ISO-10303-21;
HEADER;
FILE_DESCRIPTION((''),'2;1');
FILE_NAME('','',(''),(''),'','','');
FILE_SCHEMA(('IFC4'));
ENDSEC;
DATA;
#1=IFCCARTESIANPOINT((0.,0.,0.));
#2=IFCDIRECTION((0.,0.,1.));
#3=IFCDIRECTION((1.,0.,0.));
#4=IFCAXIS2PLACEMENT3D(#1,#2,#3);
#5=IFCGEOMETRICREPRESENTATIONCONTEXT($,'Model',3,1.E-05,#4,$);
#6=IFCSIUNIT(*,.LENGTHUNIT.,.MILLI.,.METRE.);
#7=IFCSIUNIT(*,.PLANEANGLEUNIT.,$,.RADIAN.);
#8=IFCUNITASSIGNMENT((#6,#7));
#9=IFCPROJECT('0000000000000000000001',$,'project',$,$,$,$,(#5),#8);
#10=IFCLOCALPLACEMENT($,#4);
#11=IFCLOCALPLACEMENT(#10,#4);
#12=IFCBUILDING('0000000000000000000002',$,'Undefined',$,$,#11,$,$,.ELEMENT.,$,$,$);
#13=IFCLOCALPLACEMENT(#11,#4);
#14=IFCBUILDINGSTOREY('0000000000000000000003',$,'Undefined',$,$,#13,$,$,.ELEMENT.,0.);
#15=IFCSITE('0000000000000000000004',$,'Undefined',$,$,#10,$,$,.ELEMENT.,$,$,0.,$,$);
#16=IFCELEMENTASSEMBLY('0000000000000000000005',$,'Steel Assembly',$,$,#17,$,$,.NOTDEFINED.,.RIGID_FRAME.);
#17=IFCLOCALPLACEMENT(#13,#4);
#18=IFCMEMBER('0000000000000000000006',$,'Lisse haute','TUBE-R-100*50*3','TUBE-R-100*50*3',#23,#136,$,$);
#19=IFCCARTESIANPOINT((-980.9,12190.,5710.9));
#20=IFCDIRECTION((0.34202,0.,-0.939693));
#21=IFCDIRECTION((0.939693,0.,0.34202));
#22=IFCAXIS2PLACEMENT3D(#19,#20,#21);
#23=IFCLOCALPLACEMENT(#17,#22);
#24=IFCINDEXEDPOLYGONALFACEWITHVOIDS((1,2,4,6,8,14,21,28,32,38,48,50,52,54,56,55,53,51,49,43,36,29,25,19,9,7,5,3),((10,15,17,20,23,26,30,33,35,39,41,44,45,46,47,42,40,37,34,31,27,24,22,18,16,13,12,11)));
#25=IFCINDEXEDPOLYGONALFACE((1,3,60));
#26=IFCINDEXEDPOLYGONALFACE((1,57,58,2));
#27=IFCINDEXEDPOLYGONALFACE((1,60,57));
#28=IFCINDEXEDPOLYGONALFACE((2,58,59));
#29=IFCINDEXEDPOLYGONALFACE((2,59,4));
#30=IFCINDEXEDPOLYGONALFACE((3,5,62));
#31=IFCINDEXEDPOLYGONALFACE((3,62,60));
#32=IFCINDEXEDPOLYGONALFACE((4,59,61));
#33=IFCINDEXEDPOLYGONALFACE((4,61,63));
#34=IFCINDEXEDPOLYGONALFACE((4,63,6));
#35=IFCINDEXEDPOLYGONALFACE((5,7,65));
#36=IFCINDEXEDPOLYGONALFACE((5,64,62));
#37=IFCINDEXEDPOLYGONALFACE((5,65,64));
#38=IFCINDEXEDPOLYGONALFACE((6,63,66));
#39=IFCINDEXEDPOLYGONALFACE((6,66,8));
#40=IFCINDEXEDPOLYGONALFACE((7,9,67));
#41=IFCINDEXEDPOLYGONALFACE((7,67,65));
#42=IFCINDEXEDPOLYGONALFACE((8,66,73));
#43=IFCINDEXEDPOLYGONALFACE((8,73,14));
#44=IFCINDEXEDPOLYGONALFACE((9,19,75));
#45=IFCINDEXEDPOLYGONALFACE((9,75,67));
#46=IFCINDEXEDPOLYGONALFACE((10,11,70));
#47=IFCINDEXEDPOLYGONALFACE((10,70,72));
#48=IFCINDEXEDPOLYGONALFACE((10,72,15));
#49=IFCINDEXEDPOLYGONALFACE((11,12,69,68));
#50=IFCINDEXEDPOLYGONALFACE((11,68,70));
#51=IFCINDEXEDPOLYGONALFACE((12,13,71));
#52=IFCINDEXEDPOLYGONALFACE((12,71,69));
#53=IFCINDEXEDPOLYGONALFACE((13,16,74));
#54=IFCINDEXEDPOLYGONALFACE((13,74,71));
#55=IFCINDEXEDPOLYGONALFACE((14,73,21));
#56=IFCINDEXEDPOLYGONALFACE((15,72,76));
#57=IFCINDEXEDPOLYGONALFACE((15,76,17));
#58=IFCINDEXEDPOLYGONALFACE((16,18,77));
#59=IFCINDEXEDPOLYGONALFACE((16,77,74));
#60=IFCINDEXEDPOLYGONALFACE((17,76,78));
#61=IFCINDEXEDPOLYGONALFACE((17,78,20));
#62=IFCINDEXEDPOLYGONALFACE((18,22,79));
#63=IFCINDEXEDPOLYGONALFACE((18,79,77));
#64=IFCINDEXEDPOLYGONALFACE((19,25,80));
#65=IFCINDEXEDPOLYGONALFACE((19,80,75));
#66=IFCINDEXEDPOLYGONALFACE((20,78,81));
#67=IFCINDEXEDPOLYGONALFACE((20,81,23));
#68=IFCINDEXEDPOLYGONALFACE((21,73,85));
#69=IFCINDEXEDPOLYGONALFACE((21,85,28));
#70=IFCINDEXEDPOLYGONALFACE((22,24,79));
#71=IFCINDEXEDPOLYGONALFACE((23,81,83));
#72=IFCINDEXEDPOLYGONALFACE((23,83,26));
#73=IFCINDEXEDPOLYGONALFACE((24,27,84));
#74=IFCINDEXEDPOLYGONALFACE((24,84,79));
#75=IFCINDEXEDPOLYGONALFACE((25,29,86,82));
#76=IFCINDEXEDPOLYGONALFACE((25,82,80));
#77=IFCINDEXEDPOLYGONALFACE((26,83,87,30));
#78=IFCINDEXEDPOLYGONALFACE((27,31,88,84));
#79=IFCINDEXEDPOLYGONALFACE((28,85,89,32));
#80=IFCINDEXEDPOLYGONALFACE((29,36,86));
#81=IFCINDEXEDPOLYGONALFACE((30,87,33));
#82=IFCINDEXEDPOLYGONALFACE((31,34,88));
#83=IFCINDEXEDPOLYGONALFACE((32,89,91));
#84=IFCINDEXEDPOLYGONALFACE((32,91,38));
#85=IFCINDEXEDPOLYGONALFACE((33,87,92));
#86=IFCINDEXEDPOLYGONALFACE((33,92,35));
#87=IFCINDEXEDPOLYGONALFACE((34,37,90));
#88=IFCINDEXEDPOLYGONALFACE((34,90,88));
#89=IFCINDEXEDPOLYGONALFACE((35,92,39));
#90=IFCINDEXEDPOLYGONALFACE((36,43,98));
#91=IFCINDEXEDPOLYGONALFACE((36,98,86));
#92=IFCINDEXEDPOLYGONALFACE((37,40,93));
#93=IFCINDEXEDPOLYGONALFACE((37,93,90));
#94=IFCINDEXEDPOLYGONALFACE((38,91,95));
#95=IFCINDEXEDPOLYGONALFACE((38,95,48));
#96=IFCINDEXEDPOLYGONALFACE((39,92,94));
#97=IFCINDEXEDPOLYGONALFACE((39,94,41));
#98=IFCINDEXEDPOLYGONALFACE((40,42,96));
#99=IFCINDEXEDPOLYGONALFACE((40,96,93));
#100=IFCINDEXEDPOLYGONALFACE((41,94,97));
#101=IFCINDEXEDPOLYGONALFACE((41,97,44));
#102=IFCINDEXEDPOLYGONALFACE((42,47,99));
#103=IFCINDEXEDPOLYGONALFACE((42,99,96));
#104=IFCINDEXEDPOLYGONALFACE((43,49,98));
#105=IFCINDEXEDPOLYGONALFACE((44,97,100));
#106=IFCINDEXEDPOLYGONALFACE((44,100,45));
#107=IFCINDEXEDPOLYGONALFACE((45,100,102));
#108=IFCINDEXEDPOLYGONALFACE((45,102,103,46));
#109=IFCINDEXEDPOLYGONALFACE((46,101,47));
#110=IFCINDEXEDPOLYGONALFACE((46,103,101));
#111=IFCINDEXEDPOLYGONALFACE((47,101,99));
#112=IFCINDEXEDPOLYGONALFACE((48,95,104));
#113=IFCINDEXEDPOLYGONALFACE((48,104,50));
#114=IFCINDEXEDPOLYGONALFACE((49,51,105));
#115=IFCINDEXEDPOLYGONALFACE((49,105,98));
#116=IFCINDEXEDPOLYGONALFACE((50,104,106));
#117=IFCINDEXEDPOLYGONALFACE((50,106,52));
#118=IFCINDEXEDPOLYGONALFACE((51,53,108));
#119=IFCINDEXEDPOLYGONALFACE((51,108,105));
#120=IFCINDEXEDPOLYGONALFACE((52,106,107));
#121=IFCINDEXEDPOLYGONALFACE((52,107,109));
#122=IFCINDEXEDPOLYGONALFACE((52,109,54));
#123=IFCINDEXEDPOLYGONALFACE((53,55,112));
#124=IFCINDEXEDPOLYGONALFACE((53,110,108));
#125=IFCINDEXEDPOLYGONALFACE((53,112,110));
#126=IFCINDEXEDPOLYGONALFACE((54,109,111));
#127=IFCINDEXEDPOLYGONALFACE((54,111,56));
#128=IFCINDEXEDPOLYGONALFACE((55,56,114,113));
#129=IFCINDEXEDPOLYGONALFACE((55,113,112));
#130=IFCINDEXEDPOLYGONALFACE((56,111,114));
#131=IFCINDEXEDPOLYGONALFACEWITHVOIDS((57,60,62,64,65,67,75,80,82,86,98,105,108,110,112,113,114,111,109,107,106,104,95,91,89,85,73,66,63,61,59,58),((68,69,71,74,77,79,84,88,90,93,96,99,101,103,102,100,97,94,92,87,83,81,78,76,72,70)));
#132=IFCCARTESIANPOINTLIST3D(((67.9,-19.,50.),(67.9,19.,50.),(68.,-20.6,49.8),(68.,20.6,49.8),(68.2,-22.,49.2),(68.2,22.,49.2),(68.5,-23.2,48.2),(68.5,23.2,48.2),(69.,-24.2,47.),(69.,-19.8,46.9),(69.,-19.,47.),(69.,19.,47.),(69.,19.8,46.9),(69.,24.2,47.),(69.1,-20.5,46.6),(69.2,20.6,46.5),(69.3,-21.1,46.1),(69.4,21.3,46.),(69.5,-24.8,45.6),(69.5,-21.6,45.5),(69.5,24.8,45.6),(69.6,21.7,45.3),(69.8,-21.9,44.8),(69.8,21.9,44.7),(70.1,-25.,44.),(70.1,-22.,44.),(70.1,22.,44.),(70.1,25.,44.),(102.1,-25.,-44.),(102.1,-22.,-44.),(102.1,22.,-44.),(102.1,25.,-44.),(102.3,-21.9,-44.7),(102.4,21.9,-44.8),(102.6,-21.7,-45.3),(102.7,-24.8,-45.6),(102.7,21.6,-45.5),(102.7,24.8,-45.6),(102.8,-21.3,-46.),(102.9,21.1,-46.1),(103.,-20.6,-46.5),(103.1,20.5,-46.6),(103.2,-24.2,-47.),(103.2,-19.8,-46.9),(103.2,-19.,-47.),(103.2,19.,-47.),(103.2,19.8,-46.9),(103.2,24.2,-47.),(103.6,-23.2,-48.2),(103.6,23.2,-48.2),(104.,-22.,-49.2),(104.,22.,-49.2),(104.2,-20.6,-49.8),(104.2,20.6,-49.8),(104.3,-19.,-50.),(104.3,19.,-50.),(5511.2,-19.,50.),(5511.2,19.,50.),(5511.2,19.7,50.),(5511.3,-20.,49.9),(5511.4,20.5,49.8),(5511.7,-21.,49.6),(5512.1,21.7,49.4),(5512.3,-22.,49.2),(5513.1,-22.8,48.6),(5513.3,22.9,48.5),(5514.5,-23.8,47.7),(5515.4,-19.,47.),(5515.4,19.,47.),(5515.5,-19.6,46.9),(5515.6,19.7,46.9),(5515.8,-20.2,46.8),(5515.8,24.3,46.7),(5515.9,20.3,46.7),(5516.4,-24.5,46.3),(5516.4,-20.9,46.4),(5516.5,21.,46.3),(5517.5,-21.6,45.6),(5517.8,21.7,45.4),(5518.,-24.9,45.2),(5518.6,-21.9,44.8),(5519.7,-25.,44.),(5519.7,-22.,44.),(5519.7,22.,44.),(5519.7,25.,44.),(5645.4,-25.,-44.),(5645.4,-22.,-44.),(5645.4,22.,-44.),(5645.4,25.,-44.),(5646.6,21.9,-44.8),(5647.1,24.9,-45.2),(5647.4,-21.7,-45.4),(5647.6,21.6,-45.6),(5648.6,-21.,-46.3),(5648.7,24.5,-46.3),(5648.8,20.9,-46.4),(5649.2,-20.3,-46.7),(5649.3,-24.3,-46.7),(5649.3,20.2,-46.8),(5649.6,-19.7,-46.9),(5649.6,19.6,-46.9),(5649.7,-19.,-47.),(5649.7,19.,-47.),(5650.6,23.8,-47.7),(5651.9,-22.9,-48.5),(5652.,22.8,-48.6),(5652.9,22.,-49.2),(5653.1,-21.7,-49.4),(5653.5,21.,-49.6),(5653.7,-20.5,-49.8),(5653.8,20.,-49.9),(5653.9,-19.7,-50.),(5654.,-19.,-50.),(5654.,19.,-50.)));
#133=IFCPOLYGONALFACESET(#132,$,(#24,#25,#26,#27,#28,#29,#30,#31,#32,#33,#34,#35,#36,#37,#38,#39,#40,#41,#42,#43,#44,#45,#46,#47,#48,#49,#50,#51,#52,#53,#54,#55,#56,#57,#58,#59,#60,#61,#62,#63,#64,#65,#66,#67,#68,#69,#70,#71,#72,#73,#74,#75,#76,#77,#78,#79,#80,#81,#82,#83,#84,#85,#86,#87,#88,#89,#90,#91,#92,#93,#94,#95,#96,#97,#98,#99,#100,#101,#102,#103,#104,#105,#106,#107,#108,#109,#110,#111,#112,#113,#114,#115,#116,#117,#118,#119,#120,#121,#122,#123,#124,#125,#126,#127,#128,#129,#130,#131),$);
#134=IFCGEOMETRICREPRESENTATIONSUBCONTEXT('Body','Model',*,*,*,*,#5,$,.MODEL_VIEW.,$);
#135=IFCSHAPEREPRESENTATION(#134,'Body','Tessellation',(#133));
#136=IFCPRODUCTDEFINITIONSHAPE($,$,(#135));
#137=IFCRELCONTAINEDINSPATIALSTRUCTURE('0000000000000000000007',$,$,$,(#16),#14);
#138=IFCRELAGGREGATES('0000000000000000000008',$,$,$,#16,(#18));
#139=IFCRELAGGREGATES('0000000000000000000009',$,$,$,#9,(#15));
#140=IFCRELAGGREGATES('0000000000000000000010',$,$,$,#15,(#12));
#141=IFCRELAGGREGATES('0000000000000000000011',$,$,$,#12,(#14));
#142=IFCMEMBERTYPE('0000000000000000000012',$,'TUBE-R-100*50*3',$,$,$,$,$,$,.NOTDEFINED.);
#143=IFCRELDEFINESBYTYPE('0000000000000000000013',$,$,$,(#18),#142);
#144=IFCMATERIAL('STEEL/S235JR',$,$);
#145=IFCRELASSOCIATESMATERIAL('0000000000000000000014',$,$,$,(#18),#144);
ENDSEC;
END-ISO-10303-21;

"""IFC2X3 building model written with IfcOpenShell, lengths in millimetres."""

from ifc_helpers import new_model, si_unit, frame, origin_with_axes, origin_2d_with_axis, place, context, subcontext, project, spatial, hollow_rectangle, extrude, clip, halfspace, material, type_object, element, aggregate, save


model = new_model("IFC2X3")

# Units and contexts
model_context = context("Model", 3, precision=1e-05, world=origin_with_axes())
body_context = subcontext(model_context, "Body", "Model", "MODEL_VIEW")
ifc_project = project(units=[si_unit("LENGTHUNIT", "METRE", prefix="MILLI"), si_unit("PLANEANGLEUNIT", "RADIAN")], contexts=[model_context])

# Site, building, storey
site_placement = place(None, origin_with_axes())
site = spatial("IfcSite", under=ifc_project, at=site_placement, Name="Undefined", CompositionType="ELEMENT", RefElevation=0.0)
building_placement = place(site_placement, origin_with_axes())
building = spatial("IfcBuilding", under=site, at=building_placement, Name="Undefined", CompositionType="ELEMENT")
storey_placement = place(building_placement, origin_with_axes())
storey = spatial("IfcBuildingStorey", under=building, at=storey_placement, Name="Undefined", CompositionType="ELEMENT", Elevation=0.0)

# Shared definitions
ifc_material_1 = material(Name="STEEL/S235JR")

# Element assembly, member
assembly_1_placement = place(storey_placement, origin_with_axes())
assembly_1 = element("IfcElementAssembly", 1, at=assembly_1_placement, inside=storey, Name="Steel Assembly", AssemblyPlace="NOTDEFINED", PredefinedType="RIGID_FRAME")
member_type_1 = type_object("IfcMemberType", Name="TUBE-R-100*50*3", PredefinedType="NOTDEFINED")
member_1_placement = place(assembly_1_placement, frame((-980.9, 12190.0, 5710.9), z_axis=(0.34202, 0.0, -0.939693), x_axis=(0.939693, 0.0, 0.34202)))
member_1 = element("IfcMember", 2, at=member_1_placement, type_object=member_type_1, material=ifc_material_1, Name="Lisse haute", Description="TUBE-R-100*50*3", ObjectType="TUBE-R-100*50*3", context=body_context, shape_type="Clipping", body=[
    clip(clip(extrude(hollow_rectangle(XDim=50.0, YDim=100.0, WallThickness=3.0, InnerFilletRadius=3.0, OuterFilletRadius=6.0, at=origin_2d_with_axis()), frame((5673.1, 0.0, 0.0), z_axis=(-1.0, 0.0, 0.0), x_axis=(0.0, -1.0, 0.0)), (0.0, 0.0, 1.0), 5677.5), halfspace(frame((5511.2, 0.0, 50.0), z_axis=(0.573576, 0.0, 0.819152), x_axis=(0.0, 1.0, 0.0)), False)), halfspace(frame((59.0, 0.0, 74.4), z_axis=(-0.939693, 0.0, -0.34202), x_axis=(0.34202, 0.0, -0.939693)), False)),
])

aggregate(assembly_1, [member_1])

save(model, "model.ifc")
